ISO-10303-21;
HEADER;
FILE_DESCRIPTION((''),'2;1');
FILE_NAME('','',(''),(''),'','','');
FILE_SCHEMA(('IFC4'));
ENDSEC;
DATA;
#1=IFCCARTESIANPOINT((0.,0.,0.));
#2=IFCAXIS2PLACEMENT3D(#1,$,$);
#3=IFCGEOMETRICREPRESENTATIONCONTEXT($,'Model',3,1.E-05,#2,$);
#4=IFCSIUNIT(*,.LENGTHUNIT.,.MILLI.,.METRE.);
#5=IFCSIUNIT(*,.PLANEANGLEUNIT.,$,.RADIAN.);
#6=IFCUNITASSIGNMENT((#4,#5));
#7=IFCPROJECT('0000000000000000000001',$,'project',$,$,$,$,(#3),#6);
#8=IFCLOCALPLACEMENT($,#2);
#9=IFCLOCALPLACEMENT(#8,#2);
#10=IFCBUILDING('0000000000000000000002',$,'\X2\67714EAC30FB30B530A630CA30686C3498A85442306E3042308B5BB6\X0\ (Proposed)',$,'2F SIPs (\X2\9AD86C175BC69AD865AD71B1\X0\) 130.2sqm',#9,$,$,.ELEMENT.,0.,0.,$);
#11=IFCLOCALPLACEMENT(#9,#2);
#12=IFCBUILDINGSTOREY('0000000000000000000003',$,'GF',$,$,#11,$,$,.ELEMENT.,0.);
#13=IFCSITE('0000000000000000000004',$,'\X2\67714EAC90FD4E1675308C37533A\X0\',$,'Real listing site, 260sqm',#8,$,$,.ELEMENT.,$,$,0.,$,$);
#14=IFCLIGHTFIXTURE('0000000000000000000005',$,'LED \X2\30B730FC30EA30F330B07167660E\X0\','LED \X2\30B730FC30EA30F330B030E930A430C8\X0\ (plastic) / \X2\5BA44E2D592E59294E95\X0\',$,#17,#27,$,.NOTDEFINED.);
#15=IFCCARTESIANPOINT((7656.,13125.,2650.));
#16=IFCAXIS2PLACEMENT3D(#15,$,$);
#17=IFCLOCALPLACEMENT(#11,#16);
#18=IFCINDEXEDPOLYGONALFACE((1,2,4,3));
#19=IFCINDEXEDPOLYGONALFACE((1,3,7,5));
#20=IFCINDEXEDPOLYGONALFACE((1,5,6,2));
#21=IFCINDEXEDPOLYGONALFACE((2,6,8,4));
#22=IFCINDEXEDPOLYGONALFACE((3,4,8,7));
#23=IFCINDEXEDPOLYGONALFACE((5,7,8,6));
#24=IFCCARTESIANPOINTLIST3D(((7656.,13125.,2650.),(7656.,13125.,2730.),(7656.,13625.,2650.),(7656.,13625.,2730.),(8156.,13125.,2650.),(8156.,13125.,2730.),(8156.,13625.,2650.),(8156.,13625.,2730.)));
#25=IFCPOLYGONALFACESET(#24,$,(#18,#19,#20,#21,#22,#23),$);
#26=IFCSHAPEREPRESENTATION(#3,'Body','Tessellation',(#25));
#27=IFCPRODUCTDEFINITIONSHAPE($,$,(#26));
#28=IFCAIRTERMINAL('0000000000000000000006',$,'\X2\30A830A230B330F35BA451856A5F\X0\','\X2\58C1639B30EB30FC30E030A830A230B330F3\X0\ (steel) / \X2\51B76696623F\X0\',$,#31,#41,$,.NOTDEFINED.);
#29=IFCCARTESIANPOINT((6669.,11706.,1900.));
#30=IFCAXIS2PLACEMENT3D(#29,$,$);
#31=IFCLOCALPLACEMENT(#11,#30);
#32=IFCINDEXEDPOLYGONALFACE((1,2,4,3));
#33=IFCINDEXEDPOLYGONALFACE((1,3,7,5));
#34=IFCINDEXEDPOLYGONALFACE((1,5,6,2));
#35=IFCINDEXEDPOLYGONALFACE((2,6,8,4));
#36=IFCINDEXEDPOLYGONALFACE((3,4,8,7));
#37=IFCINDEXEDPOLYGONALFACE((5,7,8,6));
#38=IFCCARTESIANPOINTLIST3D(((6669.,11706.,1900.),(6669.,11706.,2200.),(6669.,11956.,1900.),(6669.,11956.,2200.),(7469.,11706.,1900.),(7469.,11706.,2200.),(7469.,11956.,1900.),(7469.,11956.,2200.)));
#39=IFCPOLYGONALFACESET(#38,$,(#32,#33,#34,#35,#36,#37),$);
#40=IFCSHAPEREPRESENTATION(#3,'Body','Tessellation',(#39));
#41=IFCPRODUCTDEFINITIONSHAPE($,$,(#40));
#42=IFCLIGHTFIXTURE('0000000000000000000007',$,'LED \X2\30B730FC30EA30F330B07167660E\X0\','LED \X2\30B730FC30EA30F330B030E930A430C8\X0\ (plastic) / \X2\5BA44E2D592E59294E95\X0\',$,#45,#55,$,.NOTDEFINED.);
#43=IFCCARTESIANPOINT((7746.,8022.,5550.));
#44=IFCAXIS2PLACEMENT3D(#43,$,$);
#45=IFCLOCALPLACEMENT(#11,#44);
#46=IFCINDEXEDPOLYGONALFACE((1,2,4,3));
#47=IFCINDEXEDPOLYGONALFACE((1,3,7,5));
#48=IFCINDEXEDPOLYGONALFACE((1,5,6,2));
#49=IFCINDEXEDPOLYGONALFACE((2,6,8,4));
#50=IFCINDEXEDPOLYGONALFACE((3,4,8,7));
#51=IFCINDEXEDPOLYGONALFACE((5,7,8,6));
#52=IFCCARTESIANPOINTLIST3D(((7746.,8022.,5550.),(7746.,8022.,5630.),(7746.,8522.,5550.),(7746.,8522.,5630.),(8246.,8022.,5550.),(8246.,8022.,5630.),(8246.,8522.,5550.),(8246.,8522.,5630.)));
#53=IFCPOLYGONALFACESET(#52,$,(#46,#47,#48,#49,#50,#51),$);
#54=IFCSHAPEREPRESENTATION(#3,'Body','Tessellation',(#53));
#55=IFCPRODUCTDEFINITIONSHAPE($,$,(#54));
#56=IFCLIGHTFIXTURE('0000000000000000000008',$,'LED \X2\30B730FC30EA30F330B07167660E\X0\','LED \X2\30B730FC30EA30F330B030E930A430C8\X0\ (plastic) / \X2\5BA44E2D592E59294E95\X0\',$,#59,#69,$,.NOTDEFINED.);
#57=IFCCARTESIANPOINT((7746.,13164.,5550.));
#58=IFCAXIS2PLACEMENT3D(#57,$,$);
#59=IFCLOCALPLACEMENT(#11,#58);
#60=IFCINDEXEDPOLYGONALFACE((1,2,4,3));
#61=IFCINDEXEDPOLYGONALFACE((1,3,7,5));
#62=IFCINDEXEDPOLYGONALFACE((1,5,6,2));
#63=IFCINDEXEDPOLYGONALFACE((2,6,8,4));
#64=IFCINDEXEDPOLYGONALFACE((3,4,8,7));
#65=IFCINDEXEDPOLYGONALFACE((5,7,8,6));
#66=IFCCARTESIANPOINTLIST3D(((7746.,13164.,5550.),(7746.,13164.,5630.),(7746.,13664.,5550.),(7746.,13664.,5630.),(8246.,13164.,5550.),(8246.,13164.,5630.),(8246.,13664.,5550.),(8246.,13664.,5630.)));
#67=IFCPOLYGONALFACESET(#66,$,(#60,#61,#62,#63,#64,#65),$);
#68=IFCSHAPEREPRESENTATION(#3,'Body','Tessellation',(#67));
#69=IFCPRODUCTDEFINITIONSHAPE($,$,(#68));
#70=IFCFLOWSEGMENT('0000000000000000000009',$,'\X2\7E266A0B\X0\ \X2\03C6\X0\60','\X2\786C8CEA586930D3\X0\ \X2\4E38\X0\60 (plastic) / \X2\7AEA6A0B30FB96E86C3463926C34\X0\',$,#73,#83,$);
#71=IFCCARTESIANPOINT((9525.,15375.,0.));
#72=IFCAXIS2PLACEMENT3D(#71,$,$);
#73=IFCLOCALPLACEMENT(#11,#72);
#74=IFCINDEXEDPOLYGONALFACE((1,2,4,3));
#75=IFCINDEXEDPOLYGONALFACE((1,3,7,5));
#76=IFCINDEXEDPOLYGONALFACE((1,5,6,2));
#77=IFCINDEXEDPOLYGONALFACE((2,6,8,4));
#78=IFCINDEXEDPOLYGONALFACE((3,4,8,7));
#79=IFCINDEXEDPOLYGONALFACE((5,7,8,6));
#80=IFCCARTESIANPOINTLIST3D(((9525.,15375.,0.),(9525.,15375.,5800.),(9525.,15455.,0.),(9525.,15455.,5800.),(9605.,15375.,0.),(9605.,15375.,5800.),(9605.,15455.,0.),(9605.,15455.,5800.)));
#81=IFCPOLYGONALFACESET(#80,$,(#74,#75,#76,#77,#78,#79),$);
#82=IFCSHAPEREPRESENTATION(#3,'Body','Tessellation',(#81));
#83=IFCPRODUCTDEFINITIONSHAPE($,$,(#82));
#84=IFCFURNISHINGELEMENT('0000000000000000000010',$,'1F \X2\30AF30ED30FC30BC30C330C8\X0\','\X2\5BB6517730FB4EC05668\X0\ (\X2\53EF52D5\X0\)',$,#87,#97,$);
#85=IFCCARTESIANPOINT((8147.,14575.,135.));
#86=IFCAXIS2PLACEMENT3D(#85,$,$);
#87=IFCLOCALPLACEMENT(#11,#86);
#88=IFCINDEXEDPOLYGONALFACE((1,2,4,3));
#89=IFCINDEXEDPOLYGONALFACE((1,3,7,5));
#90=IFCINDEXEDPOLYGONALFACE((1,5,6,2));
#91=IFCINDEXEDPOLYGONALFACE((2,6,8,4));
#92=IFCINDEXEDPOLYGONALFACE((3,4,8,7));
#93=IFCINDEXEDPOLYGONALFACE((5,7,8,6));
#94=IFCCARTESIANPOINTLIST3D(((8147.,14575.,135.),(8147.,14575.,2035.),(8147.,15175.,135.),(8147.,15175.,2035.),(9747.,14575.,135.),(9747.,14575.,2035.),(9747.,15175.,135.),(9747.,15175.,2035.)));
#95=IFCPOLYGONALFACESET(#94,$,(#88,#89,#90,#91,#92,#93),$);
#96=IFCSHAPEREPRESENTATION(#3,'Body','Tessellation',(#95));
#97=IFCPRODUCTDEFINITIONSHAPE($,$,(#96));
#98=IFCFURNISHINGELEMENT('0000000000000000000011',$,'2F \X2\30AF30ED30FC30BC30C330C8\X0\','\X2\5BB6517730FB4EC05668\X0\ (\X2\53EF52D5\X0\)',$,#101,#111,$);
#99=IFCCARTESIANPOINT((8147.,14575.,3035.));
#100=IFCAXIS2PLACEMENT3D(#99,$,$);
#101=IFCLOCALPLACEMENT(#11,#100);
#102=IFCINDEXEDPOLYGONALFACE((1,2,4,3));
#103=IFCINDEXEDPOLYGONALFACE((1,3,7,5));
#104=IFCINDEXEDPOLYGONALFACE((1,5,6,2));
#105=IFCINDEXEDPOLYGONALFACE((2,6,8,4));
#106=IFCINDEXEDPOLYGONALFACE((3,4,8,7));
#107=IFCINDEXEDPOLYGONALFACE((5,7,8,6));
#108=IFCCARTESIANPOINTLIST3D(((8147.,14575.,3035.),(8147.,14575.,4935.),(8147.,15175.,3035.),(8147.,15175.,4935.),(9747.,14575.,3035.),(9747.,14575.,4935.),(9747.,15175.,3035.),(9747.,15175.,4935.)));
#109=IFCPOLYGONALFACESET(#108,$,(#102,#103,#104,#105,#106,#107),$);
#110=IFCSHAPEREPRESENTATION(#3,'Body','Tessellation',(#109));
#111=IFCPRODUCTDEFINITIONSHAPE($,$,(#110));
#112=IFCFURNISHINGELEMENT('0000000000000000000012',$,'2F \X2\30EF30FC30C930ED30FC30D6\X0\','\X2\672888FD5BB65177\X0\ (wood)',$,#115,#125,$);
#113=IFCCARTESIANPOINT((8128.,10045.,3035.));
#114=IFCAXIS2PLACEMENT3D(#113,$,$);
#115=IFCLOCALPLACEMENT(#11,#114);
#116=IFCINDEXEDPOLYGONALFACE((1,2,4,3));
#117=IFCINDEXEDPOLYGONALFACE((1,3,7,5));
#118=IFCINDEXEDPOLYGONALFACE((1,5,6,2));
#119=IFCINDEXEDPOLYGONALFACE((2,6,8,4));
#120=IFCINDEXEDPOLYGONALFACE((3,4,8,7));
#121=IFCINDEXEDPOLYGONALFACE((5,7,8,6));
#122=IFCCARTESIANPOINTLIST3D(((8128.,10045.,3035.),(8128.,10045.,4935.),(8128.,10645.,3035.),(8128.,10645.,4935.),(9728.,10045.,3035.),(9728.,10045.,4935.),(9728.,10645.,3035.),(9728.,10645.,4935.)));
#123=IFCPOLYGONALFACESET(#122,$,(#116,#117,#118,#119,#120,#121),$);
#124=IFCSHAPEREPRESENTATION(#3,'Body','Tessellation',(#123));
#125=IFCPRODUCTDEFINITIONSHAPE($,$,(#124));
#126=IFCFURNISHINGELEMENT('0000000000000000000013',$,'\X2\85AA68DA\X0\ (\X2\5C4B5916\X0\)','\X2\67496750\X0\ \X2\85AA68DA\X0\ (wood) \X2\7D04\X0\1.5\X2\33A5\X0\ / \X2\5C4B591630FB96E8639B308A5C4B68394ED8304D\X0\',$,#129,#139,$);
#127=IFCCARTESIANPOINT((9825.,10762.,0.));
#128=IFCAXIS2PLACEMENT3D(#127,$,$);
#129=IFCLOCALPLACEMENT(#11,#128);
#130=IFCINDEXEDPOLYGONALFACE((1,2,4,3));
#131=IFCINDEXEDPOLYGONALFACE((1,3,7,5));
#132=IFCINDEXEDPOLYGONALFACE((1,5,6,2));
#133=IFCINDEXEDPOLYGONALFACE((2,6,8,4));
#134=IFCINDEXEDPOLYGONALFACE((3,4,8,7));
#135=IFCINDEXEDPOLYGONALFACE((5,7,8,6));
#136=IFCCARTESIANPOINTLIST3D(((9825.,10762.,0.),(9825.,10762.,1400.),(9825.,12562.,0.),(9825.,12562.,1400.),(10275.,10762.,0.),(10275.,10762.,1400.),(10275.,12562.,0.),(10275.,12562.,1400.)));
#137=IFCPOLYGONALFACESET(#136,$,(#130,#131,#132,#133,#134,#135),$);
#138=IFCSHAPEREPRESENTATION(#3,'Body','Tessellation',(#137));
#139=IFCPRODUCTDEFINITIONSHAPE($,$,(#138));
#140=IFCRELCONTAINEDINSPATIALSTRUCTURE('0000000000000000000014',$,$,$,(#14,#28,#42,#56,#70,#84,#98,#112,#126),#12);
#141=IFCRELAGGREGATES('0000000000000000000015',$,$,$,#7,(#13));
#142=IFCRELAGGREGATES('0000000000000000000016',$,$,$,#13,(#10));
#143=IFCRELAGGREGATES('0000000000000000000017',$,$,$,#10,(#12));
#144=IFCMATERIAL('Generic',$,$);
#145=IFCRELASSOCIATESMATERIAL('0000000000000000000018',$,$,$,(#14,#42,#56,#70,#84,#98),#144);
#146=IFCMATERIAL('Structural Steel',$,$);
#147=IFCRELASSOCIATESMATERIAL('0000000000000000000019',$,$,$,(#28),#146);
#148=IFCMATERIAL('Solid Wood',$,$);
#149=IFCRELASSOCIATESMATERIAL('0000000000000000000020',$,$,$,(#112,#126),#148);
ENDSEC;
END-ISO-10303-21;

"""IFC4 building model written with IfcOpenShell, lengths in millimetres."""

from ifc_helpers import new_model, si_unit, frame, frame_2d, origin, place, context, project, spatial, rectangle, extrude, material, element, save


model = new_model("IFC4")

# Units and contexts
model_context = context("Model", 3, precision=1e-05, world=origin())
ifc_project = project(units=[si_unit("LENGTHUNIT", "METRE", prefix="MILLI"), si_unit("PLANEANGLEUNIT", "RADIAN")], contexts=[model_context])

# Site, building, storey
site_placement = place(None, origin())
site = spatial("IfcSite", under=ifc_project, at=site_placement, Name="東京都世田谷区", ObjectType="Real listing site, 260sqm", CompositionType="ELEMENT", RefElevation=0.0)
building_placement = place(site_placement, origin())
building = spatial("IfcBuilding", under=site, at=building_placement, Name="東京・サウナと水風呂のある家 (Proposed)", ObjectType="2F SIPs (高気密高断熱) 130.2sqm", CompositionType="ELEMENT", ElevationOfRefHeight=0.0, ElevationOfTerrain=0.0)
storey_placement = place(building_placement, origin())
storey = spatial("IfcBuildingStorey", under=building, at=storey_placement, Name="GF", CompositionType="ELEMENT", Elevation=0.0)

# Shared definitions
ifc_material_1 = material(Name="Solid Wood")

# Shared definitions
ifc_material_2 = material(Name="Structural Steel")

# Shared definitions
ifc_material_3 = material(Name="Generic")

# Light fixture
light_fixture_1_placement = place(storey_placement, frame((7656.0, 13125.0, 2650.0)))
element("IfcLightFixture", 1, at=light_fixture_1_placement, inside=storey, material=ifc_material_3, Name="LED シーリング照明", Description="LED シーリングライト (plastic) / 室中央天井", PredefinedType="NOTDEFINED", context=model_context, shape_type="SweptSolid", body=[
    extrude(rectangle(XDim=500.0, YDim=500.0, at=frame_2d((250.0, 250.0))), frame((7656.0, 13125.0, 2650.0)), (0.0, 0.0, 1.0), 80.0),
])

# Air terminal
air_terminal_placement = place(storey_placement, frame((6669.0, 11706.0, 1900.0)))
element("IfcAirTerminal", 2, at=air_terminal_placement, inside=storey, material=ifc_material_2, Name="エアコン室内機", Description="壁掛ルームエアコン (steel) / 冷暖房", PredefinedType="NOTDEFINED", context=model_context, shape_type="SweptSolid", body=[
    extrude(rectangle(XDim=800.0, YDim=250.0, at=frame_2d((400.0, 125.0))), frame((6669.0, 11706.0, 1900.0)), (0.0, 0.0, 1.0), 300.0),
])

# Light fixtures
light_fixture_2_placement = place(storey_placement, frame((7746.0, 8022.0, 5550.0)))
element("IfcLightFixture", 3, at=light_fixture_2_placement, inside=storey, material=ifc_material_3, Name="LED シーリング照明", Description="LED シーリングライト (plastic) / 室中央天井", PredefinedType="NOTDEFINED", context=model_context, shape_type="SweptSolid", body=[
    extrude(rectangle(XDim=500.0, YDim=500.0, at=frame_2d((250.0, 250.0))), frame((7746.0, 8022.0, 5550.0)), (0.0, 0.0, 1.0), 80.0),
])
light_fixture_3_placement = place(storey_placement, frame((7746.0, 13164.0, 5550.0)))
element("IfcLightFixture", 4, at=light_fixture_3_placement, inside=storey, material=ifc_material_3, Name="LED シーリング照明", Description="LED シーリングライト (plastic) / 室中央天井", PredefinedType="NOTDEFINED", context=model_context, shape_type="SweptSolid", body=[
    extrude(rectangle(XDim=500.0, YDim=500.0, at=frame_2d((250.0, 250.0))), frame((7746.0, 13164.0, 5550.0)), (0.0, 0.0, 1.0), 80.0),
])

# Flow segment
flow_segment_placement = place(storey_placement, frame((9525.0, 15375.0, 0.0)))
element("IfcFlowSegment", 5, at=flow_segment_placement, inside=storey, material=ifc_material_3, Name="縦樋 φ60", Description="硬質塩ビ 丸60 (plastic) / 竪樋・雨水排水", context=model_context, shape_type="SweptSolid", body=[
    extrude(rectangle(XDim=80.0, YDim=80.0, at=frame_2d((40.0, 40.0))), frame((9525.0, 15375.0, 0.0)), (0.0, 0.0, 1.0), 5800.0),
])

# Furnishing elements
furnishing_1_placement = place(storey_placement, frame((8147.0, 14575.0, 135.0)))
element("IfcFurnishingElement", 6, at=furnishing_1_placement, inside=storey, material=ifc_material_3, Name="1F クローゼット", Description="家具・什器 (可動)", context=model_context, shape_type="SweptSolid", body=[
    extrude(rectangle(XDim=1600.0, YDim=600.0, at=frame_2d((800.0, 300.0))), frame((8147.0, 14575.0, 135.0)), (0.0, 0.0, 1.0), 1900.0),
])
furnishing_2_placement = place(storey_placement, frame((8147.0, 14575.0, 3035.0)))
element("IfcFurnishingElement", 7, at=furnishing_2_placement, inside=storey, material=ifc_material_3, Name="2F クローゼット", Description="家具・什器 (可動)", context=model_context, shape_type="SweptSolid", body=[
    extrude(rectangle(XDim=1600.0, YDim=600.0, at=frame_2d((800.0, 300.0))), frame((8147.0, 14575.0, 3035.0)), (0.0, 0.0, 1.0), 1900.0),
])
furnishing_3_placement = place(storey_placement, frame((8128.0, 10045.0, 3035.0)))
element("IfcFurnishingElement", 8, at=furnishing_3_placement, inside=storey, material=ifc_material_1, Name="2F ワードローブ", Description="木製家具 (wood)", context=model_context, shape_type="SweptSolid", body=[
    extrude(rectangle(XDim=1600.0, YDim=600.0, at=frame_2d((800.0, 300.0))), frame((8128.0, 10045.0, 3035.0)), (0.0, 0.0, 1.0), 1900.0),
])
furnishing_4_placement = place(storey_placement, frame((9825.0, 10762.0, 0.0)))
element("IfcFurnishingElement", 9, at=furnishing_4_placement, inside=storey, material=ifc_material_1, Name="薪棚 (屋外)", Description="杉材 薪棚 (wood) 約1.5㎥ / 屋外・雨掛り屋根付き", context=model_context, shape_type="SweptSolid", body=[
    extrude(rectangle(XDim=450.0, YDim=1800.0, at=frame_2d((225.0, 900.0))), frame((9825.0, 10762.0, 0.0)), (0.0, 0.0, 1.0), 1400.0),
])

save(model, "model.ifc")
